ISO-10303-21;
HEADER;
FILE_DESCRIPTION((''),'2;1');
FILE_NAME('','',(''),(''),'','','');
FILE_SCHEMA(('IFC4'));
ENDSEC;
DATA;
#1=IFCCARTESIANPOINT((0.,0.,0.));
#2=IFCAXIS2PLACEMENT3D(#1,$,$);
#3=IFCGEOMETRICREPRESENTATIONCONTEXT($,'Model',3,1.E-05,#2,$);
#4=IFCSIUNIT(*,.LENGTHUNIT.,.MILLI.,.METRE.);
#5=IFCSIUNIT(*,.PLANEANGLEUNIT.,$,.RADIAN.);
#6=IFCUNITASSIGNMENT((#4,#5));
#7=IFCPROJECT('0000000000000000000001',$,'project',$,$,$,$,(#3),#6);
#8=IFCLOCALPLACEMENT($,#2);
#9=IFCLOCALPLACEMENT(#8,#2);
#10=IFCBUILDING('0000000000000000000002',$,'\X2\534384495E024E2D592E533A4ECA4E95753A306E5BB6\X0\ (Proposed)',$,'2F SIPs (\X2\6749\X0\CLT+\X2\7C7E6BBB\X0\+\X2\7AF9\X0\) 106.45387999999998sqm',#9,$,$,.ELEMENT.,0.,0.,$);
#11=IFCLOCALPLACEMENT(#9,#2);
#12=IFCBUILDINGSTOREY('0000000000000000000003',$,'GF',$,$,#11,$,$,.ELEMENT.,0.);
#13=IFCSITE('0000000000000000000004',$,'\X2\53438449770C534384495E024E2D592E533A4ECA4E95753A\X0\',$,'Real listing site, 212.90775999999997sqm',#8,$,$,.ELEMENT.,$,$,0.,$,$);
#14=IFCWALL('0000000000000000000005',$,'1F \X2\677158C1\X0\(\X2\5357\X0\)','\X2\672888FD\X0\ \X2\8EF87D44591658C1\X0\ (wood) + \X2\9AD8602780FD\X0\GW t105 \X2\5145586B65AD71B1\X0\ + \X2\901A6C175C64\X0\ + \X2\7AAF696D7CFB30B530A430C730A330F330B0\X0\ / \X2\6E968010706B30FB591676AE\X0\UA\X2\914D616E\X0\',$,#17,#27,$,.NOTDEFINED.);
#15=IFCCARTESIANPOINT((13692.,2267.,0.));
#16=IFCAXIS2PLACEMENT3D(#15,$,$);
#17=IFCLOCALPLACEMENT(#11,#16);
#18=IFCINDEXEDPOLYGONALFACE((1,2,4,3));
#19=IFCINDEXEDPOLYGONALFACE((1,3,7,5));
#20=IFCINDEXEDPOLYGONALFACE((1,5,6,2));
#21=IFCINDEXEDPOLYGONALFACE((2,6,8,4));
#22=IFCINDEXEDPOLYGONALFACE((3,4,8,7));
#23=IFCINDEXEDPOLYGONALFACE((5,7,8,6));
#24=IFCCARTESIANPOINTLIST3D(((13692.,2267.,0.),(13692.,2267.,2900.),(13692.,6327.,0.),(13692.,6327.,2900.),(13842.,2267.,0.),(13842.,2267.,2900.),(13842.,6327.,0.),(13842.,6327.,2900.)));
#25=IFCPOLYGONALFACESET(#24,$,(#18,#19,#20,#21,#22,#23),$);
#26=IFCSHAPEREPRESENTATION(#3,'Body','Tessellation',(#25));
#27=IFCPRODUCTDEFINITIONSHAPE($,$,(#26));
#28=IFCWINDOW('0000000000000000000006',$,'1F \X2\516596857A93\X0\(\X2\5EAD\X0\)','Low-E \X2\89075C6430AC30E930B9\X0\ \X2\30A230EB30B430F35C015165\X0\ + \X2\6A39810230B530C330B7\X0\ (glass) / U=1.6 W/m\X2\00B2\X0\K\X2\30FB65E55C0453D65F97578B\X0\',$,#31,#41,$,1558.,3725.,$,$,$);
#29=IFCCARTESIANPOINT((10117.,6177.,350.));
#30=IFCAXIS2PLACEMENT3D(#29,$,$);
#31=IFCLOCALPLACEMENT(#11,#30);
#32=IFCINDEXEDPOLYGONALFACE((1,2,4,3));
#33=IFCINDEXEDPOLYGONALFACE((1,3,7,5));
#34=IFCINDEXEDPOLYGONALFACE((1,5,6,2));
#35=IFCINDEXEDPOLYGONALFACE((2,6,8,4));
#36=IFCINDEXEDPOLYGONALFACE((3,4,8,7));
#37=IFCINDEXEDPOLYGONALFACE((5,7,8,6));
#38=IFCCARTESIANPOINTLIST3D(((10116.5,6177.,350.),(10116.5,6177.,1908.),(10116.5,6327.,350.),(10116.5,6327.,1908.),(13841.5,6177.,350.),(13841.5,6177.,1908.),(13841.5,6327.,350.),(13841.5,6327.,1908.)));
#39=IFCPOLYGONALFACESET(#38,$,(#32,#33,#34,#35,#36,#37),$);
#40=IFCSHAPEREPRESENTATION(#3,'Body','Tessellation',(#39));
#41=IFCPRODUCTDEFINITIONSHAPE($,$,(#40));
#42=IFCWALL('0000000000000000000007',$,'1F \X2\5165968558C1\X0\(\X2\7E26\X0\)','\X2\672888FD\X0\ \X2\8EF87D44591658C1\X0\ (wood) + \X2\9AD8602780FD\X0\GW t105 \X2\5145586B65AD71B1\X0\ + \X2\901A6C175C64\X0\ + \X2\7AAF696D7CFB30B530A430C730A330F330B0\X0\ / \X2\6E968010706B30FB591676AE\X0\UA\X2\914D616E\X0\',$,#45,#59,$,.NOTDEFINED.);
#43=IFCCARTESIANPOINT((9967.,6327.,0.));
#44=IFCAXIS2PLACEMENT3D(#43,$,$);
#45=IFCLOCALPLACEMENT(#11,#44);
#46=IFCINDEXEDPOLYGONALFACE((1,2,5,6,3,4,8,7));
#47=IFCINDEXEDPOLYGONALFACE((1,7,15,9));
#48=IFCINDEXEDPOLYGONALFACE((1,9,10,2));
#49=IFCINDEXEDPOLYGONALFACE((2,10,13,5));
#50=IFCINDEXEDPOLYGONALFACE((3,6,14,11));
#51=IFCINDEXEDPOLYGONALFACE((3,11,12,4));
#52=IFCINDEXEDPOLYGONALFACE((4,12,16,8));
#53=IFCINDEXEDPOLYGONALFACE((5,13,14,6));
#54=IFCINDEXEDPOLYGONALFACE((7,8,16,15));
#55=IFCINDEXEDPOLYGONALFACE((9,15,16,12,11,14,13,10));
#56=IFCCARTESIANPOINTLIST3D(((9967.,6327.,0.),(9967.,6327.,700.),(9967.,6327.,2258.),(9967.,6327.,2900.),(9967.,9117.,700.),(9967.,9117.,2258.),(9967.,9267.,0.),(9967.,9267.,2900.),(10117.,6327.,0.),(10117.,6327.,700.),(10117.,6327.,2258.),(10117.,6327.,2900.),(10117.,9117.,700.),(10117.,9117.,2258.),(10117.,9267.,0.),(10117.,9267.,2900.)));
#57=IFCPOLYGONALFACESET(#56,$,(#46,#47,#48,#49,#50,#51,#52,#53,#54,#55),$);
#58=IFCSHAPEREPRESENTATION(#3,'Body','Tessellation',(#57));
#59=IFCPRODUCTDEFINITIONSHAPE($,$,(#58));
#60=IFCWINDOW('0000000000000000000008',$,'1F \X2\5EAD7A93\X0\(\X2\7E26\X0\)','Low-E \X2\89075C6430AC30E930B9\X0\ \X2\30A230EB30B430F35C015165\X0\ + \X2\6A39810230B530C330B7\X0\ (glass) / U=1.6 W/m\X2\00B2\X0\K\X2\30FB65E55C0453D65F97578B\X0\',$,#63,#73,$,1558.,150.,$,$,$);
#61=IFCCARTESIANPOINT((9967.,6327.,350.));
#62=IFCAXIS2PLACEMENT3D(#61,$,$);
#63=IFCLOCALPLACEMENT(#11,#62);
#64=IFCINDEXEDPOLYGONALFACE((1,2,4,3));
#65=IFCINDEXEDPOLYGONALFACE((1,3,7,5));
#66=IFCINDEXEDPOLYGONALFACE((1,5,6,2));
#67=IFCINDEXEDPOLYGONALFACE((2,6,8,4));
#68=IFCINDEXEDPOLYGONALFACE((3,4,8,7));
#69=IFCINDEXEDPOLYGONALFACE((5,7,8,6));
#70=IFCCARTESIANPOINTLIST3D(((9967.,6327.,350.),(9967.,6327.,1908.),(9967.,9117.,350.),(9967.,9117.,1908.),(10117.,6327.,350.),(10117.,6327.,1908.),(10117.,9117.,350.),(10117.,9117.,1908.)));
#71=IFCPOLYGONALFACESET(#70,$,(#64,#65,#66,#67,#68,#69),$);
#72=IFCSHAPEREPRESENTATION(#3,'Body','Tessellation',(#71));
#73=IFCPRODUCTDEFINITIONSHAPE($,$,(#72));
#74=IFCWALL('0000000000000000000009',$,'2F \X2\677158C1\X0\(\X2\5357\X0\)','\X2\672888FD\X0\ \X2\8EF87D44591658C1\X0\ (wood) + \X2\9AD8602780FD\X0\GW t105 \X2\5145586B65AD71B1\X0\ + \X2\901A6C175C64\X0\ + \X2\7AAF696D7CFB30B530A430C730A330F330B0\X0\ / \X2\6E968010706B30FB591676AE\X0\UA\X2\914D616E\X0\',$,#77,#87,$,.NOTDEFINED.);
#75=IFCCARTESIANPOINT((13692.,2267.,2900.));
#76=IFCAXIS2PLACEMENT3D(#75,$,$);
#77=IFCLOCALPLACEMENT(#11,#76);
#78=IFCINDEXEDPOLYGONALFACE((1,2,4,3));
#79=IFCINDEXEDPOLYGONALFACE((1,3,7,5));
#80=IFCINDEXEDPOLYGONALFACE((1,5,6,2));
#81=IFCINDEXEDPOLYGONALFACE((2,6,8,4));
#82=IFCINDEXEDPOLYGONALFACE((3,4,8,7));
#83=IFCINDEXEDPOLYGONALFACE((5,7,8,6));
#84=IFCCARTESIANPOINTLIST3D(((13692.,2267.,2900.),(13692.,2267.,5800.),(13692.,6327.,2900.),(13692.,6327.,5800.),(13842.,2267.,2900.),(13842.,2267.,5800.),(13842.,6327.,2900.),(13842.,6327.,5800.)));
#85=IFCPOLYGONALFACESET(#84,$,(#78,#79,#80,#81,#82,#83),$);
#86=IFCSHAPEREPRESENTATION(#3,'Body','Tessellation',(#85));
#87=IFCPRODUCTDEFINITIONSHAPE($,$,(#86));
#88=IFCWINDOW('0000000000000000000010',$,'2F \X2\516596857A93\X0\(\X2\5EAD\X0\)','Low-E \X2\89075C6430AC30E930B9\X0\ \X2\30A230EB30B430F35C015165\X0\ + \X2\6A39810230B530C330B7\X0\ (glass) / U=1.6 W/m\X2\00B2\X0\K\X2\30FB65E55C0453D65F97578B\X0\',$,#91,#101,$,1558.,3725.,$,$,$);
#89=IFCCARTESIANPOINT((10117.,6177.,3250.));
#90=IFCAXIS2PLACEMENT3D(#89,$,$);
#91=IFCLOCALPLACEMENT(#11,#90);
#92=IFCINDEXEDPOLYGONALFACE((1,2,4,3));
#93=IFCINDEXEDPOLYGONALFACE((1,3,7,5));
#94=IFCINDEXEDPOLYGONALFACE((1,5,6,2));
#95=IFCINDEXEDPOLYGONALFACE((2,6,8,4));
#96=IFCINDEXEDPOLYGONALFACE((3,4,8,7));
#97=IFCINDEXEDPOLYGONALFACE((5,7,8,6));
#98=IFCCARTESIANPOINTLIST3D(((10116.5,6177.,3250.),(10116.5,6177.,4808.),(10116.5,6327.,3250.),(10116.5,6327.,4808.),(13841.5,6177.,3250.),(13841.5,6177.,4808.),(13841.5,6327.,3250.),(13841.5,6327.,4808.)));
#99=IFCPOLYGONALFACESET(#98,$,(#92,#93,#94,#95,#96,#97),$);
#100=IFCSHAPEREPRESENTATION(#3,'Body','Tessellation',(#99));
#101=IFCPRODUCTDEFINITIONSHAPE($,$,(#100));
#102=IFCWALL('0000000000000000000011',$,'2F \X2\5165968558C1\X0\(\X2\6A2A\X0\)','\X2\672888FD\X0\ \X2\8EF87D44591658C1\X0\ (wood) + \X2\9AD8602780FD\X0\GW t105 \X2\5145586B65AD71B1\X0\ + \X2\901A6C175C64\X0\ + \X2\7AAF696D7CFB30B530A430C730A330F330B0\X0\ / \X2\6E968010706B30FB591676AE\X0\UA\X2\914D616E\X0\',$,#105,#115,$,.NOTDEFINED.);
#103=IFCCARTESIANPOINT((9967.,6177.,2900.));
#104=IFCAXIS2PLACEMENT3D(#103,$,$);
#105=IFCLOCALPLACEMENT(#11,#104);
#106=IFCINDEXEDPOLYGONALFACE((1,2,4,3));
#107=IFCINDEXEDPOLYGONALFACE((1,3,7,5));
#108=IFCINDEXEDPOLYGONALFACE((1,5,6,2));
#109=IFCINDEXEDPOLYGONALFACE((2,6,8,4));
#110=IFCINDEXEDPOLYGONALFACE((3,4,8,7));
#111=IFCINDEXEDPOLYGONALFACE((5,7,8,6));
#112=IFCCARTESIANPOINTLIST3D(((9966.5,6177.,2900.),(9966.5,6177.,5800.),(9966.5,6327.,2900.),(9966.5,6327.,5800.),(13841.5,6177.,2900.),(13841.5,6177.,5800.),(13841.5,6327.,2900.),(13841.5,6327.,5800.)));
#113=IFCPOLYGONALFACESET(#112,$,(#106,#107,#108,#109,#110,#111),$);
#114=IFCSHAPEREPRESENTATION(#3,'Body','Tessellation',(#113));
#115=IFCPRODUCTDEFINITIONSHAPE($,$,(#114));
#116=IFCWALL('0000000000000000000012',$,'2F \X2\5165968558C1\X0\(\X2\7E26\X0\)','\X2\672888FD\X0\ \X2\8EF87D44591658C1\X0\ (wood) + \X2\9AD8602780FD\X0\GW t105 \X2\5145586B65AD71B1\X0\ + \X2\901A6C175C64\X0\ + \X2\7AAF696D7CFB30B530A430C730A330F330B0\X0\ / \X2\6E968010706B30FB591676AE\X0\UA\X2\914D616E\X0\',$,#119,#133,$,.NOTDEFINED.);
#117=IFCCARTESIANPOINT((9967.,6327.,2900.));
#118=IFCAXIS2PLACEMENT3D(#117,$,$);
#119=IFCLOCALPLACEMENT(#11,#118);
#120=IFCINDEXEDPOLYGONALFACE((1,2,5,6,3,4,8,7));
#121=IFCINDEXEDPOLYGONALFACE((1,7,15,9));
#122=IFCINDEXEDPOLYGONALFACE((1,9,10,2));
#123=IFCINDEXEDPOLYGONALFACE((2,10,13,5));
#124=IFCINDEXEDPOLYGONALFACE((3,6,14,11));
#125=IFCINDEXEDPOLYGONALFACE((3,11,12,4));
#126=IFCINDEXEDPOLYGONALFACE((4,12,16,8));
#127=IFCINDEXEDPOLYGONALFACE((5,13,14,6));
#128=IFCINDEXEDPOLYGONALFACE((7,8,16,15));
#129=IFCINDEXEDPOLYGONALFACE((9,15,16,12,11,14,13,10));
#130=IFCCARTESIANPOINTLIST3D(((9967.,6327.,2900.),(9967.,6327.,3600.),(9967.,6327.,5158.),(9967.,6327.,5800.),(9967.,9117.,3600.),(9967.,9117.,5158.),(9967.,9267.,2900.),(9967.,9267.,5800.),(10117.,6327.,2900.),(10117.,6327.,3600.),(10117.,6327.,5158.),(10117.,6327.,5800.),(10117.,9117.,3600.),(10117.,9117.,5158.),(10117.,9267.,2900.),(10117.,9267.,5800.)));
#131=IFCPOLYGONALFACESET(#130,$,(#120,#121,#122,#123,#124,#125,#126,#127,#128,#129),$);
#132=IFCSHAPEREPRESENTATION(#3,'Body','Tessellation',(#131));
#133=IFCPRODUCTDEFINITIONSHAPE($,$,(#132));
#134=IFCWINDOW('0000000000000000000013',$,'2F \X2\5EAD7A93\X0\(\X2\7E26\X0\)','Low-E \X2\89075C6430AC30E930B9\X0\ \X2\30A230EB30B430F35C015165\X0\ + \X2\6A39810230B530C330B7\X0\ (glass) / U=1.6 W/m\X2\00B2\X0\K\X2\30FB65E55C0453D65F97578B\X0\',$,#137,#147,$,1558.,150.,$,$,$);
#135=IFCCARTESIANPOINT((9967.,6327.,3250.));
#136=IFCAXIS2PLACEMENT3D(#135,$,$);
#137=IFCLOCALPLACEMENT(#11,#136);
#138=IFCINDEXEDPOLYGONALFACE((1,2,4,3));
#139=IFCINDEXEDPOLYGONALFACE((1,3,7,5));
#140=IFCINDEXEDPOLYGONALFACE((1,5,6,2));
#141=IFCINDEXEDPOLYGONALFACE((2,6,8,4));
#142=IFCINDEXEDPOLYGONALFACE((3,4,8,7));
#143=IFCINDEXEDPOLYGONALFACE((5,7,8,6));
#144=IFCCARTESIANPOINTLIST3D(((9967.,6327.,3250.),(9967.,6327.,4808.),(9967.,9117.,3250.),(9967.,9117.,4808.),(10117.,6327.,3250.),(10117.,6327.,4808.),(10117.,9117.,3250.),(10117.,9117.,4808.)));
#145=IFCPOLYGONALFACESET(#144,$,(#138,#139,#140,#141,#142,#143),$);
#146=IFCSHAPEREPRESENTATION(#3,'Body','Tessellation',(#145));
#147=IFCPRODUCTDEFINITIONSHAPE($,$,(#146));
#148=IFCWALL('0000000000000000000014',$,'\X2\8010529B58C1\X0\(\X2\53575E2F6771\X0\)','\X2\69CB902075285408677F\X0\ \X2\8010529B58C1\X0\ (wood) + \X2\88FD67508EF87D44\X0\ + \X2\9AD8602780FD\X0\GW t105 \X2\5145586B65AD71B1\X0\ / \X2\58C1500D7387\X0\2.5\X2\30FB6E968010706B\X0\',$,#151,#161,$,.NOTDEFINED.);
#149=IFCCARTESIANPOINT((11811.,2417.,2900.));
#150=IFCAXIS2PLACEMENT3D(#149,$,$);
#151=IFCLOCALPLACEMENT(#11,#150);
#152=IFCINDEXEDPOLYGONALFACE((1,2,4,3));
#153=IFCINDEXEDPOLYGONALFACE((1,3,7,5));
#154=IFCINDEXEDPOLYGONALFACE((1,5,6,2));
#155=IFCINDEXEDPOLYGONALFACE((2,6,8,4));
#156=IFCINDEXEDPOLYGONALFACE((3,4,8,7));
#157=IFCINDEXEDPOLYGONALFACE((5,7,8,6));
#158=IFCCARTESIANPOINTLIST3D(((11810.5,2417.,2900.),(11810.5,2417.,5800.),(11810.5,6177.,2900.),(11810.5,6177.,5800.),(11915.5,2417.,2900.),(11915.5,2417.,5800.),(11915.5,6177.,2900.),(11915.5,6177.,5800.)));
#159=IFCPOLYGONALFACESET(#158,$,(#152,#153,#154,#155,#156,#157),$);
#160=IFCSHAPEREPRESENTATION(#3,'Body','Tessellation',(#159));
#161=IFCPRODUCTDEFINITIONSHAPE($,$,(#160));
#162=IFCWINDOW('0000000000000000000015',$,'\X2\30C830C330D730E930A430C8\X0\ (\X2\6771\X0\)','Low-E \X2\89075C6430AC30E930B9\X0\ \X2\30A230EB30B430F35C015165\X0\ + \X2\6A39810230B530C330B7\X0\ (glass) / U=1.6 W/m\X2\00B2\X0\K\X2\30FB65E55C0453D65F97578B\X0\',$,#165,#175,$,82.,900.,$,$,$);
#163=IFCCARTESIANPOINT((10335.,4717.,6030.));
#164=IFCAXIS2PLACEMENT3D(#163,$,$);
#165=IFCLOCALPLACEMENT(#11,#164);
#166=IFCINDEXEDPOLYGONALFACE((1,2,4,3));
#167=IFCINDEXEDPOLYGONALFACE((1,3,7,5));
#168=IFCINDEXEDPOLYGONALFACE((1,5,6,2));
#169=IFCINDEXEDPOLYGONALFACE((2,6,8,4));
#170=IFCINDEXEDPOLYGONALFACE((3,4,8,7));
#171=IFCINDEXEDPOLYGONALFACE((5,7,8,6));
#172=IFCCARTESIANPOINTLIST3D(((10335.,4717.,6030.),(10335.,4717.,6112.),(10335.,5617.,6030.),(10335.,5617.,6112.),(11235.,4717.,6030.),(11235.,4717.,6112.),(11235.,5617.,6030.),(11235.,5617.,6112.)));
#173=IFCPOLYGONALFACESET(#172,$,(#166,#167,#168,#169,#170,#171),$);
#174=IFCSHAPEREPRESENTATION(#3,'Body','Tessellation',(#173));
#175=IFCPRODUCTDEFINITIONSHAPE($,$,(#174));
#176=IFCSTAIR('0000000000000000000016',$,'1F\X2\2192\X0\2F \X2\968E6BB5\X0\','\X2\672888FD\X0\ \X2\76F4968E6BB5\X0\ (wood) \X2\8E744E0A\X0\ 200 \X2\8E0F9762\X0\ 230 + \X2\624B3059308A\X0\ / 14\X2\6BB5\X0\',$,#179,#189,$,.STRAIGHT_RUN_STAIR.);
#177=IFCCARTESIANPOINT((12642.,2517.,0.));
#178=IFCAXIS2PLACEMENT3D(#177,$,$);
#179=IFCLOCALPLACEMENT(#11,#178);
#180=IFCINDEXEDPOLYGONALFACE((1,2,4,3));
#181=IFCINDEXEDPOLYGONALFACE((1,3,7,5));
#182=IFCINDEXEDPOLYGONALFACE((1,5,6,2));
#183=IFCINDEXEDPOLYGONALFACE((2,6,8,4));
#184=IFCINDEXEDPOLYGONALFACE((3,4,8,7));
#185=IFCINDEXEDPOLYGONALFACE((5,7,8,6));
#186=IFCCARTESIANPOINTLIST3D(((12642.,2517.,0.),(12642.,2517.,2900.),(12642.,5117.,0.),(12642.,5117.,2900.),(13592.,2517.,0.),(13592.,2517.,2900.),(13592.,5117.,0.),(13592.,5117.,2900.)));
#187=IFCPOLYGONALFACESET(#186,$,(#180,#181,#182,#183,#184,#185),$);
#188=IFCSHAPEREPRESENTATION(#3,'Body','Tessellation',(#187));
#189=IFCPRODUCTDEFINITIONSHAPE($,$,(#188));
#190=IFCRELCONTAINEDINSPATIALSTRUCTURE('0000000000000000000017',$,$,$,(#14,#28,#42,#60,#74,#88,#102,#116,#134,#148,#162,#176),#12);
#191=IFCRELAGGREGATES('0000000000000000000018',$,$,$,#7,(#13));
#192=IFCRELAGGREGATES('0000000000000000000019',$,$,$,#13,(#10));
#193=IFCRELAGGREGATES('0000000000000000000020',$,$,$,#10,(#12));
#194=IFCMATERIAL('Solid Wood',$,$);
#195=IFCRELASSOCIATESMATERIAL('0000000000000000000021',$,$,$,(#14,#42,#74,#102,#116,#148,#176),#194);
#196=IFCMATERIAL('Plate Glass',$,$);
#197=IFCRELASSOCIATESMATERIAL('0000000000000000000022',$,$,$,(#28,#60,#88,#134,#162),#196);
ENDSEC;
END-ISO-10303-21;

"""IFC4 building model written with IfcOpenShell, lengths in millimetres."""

from ifc_helpers import new_model, si_unit, frame, frame_2d, origin, place, context, project, spatial, rectangle, extrude, material, element, fill, save


model = new_model("IFC4")

# Units and contexts
model_context = context("Model", 3, precision=1e-05, world=origin())
ifc_project = project(units=[si_unit("LENGTHUNIT", "METRE", prefix="MILLI"), si_unit("PLANEANGLEUNIT", "RADIAN")], contexts=[model_context])

# Site, building, storey
site_placement = place(None, origin())
site = spatial("IfcSite", under=ifc_project, at=site_placement, Name="千葉県千葉市中央区今井町", ObjectType="Real listing site, 212.90775999999997sqm", CompositionType="ELEMENT", RefElevation=0.0)
building_placement = place(site_placement, origin())
building = spatial("IfcBuilding", under=site, at=building_placement, Name="千葉市中央区今井町の家 (Proposed)", ObjectType="2F SIPs (杉CLT+籾殻+竹) 106.45387999999998sqm", CompositionType="ELEMENT", ElevationOfRefHeight=0.0, ElevationOfTerrain=0.0)
storey_placement = place(building_placement, origin())
storey = spatial("IfcBuildingStorey", under=building, at=storey_placement, Name="GF", CompositionType="ELEMENT", Elevation=0.0)

# Shared definitions
ifc_material_1 = material(Name="Solid Wood")

# Wall, opening, window
wall_1_placement = place(storey_placement, frame((13692.0, 2267.0, 0.0)))
wall_1 = element("IfcWall", 1, at=wall_1_placement, inside=storey, material=ifc_material_1, Name="1F 東壁(南)", Description="木製 軸組外壁 (wood) + 高性能GW t105 充填断熱 + 通気層 + 窯業系サイディング / 準耐火・外皮UA配慮", PredefinedType="NOTDEFINED", context=model_context, shape_type="SweptSolid", body=[
    extrude(rectangle(XDim=150.0, YDim=4060.0, at=frame_2d((75.0, 2030.0))), frame((13692.0, 2267.0, 0.0)), (0.0, 0.0, 1.0), 2900.0),
])
opening_1_placement = place(storey_placement, frame((10117.0, 6177.0, 350.0)))
opening_1 = element("IfcOpeningElement", 2, at=opening_1_placement, cuts=wall_1, PredefinedType="NOTDEFINED", context=model_context, shape_type="SweptSolid", body=[
    extrude(rectangle(XDim=3725.0, YDim=150.0, at=frame_2d((1862.0, 75.0))), frame((10117.0, 6177.0, 350.0)), (0.0, 0.0, 1.0), 1558.0),
])
ifc_material_2 = material(Name="Plate Glass")
window_1_placement = place(storey_placement, frame((10117.0, 6177.0, 350.0)))
window_1 = element("IfcWindow", 3, at=window_1_placement, inside=storey, material=ifc_material_2, Name="1F 入隅窓(庭)", Description="Low-E 複層ガラス アルゴン封入 + 樹脂サッシ (glass) / U=1.6 W/m²K・日射取得型", OverallHeight=1558.0, OverallWidth=3725.0, context=model_context, shape_type="SweptSolid", body=[
    extrude(rectangle(XDim=3725.0, YDim=150.0, at=frame_2d((1862.0, 75.0))), frame((10117.0, 6177.0, 350.0)), (0.0, 0.0, 1.0), 1558.0),
])
fill(opening_1, window_1)

# Wall, opening, window
wall_2_placement = place(storey_placement, frame((9967.0, 6327.0, 0.0)))
wall_2 = element("IfcWall", 4, at=wall_2_placement, inside=storey, material=ifc_material_1, Name="1F 入隅壁(縦)", Description="木製 軸組外壁 (wood) + 高性能GW t105 充填断熱 + 通気層 + 窯業系サイディング / 準耐火・外皮UA配慮", PredefinedType="NOTDEFINED", context=model_context, shape_type="SweptSolid", body=[
    extrude(rectangle(XDim=150.0, YDim=2940.0, at=frame_2d((75.0, 1470.0))), frame((9967.0, 6327.0, 0.0)), (0.0, 0.0, 1.0), 2900.0),
])
opening_2_placement = place(storey_placement, frame((9967.0, 6327.0, 350.0)))
opening_2 = element("IfcOpeningElement", 5, at=opening_2_placement, cuts=wall_2, PredefinedType="NOTDEFINED", context=model_context, shape_type="SweptSolid", body=[
    extrude(rectangle(XDim=150.0, YDim=2790.0, at=frame_2d((75.0, 1395.0))), frame((9967.0, 6327.0, 350.0)), (0.0, 0.0, 1.0), 1558.0),
])
window_2_placement = place(storey_placement, frame((9967.0, 6327.0, 350.0)))
window_2 = element("IfcWindow", 6, at=window_2_placement, inside=storey, material=ifc_material_2, Name="1F 庭窓(縦)", Description="Low-E 複層ガラス アルゴン封入 + 樹脂サッシ (glass) / U=1.6 W/m²K・日射取得型", OverallHeight=1558.0, OverallWidth=150.0, context=model_context, shape_type="SweptSolid", body=[
    extrude(rectangle(XDim=150.0, YDim=2790.0, at=frame_2d((75.0, 1395.0))), frame((9967.0, 6327.0, 350.0)), (0.0, 0.0, 1.0), 1558.0),
])
fill(opening_2, window_2)

# Wall, opening, window
wall_3_placement = place(storey_placement, frame((13692.0, 2267.0, 2900.0)))
wall_3 = element("IfcWall", 7, at=wall_3_placement, inside=storey, material=ifc_material_1, Name="2F 東壁(南)", Description="木製 軸組外壁 (wood) + 高性能GW t105 充填断熱 + 通気層 + 窯業系サイディング / 準耐火・外皮UA配慮", PredefinedType="NOTDEFINED", context=model_context, shape_type="SweptSolid", body=[
    extrude(rectangle(XDim=150.0, YDim=4060.0, at=frame_2d((75.0, 2030.0))), frame((13692.0, 2267.0, 2900.0)), (0.0, 0.0, 1.0), 2900.0),
])
opening_3_placement = place(storey_placement, frame((10117.0, 6177.0, 3250.0)))
opening_3 = element("IfcOpeningElement", 8, at=opening_3_placement, cuts=wall_3, PredefinedType="NOTDEFINED", context=model_context, shape_type="SweptSolid", body=[
    extrude(rectangle(XDim=3725.0, YDim=150.0, at=frame_2d((1862.0, 75.0))), frame((10117.0, 6177.0, 3250.0)), (0.0, 0.0, 1.0), 1558.0),
])
window_3_placement = place(storey_placement, frame((10117.0, 6177.0, 3250.0)))
window_3 = element("IfcWindow", 9, at=window_3_placement, inside=storey, material=ifc_material_2, Name="2F 入隅窓(庭)", Description="Low-E 複層ガラス アルゴン封入 + 樹脂サッシ (glass) / U=1.6 W/m²K・日射取得型", OverallHeight=1558.0, OverallWidth=3725.0, context=model_context, shape_type="SweptSolid", body=[
    extrude(rectangle(XDim=3725.0, YDim=150.0, at=frame_2d((1862.0, 75.0))), frame((10117.0, 6177.0, 3250.0)), (0.0, 0.0, 1.0), 1558.0),
])
fill(opening_3, window_3)

# Wall
wall_4_placement = place(storey_placement, frame((9967.0, 6177.0, 2900.0)))
element("IfcWall", 10, at=wall_4_placement, inside=storey, material=ifc_material_1, Name="2F 入隅壁(横)", Description="木製 軸組外壁 (wood) + 高性能GW t105 充填断熱 + 通気層 + 窯業系サイディング / 準耐火・外皮UA配慮", PredefinedType="NOTDEFINED", context=model_context, shape_type="SweptSolid", body=[
    extrude(rectangle(XDim=3875.0, YDim=150.0, at=frame_2d((1937.0, 75.0))), frame((9967.0, 6177.0, 2900.0)), (0.0, 0.0, 1.0), 2900.0),
])

# Wall, opening, window
wall_5_placement = place(storey_placement, frame((9967.0, 6327.0, 2900.0)))
wall_5 = element("IfcWall", 11, at=wall_5_placement, inside=storey, material=ifc_material_1, Name="2F 入隅壁(縦)", Description="木製 軸組外壁 (wood) + 高性能GW t105 充填断熱 + 通気層 + 窯業系サイディング / 準耐火・外皮UA配慮", PredefinedType="NOTDEFINED", context=model_context, shape_type="SweptSolid", body=[
    extrude(rectangle(XDim=150.0, YDim=2940.0, at=frame_2d((75.0, 1470.0))), frame((9967.0, 6327.0, 2900.0)), (0.0, 0.0, 1.0), 2900.0),
])
opening_4_placement = place(storey_placement, frame((9967.0, 6327.0, 3250.0)))
opening_4 = element("IfcOpeningElement", 12, at=opening_4_placement, cuts=wall_5, PredefinedType="NOTDEFINED", context=model_context, shape_type="SweptSolid", body=[
    extrude(rectangle(XDim=150.0, YDim=2790.0, at=frame_2d((75.0, 1395.0))), frame((9967.0, 6327.0, 3250.0)), (0.0, 0.0, 1.0), 1558.0),
])
window_4_placement = place(storey_placement, frame((9967.0, 6327.0, 3250.0)))
window_4 = element("IfcWindow", 13, at=window_4_placement, inside=storey, material=ifc_material_2, Name="2F 庭窓(縦)", Description="Low-E 複層ガラス アルゴン封入 + 樹脂サッシ (glass) / U=1.6 W/m²K・日射取得型", OverallHeight=1558.0, OverallWidth=150.0, context=model_context, shape_type="SweptSolid", body=[
    extrude(rectangle(XDim=150.0, YDim=2790.0, at=frame_2d((75.0, 1395.0))), frame((9967.0, 6327.0, 3250.0)), (0.0, 0.0, 1.0), 1558.0),
])
fill(opening_4, window_4)

# Wall
wall_6_placement = place(storey_placement, frame((11811.0, 2417.0, 2900.0)))
element("IfcWall", 14, at=wall_6_placement, inside=storey, material=ifc_material_1, Name="耐力壁(南帯東)", Description="構造用合板 耐力壁 (wood) + 製材軸組 + 高性能GW t105 充填断熱 / 壁倍率2.5・準耐火", PredefinedType="NOTDEFINED", context=model_context, shape_type="SweptSolid", body=[
    extrude(rectangle(XDim=105.0, YDim=3760.0, at=frame_2d((52.0, 1880.0))), frame((11811.0, 2417.0, 2900.0)), (0.0, 0.0, 1.0), 2900.0),
])

# Window
window_5_placement = place(storey_placement, frame((10335.0, 4717.0, 6030.0)))
element("IfcWindow", 15, at=window_5_placement, inside=storey, material=ifc_material_2, Name="トップライト (東)", Description="Low-E 複層ガラス アルゴン封入 + 樹脂サッシ (glass) / U=1.6 W/m²K・日射取得型", OverallHeight=82.0, OverallWidth=900.0, context=model_context, shape_type="SweptSolid", body=[
    extrude(rectangle(XDim=900.0, YDim=900.0, at=frame_2d((450.0, 450.0))), frame((10335.0, 4717.0, 6030.0)), (0.0, 0.0, 1.0), 82.0),
])

# Stair
stair_placement = place(storey_placement, frame((12642.0, 2517.0, 0.0)))
element("IfcStair", 16, at=stair_placement, inside=storey, material=ifc_material_1, Name="1F→2F 階段", Description="木製 直階段 (wood) 蹴上 200 踏面 230 + 手すり / 14段", PredefinedType="STRAIGHT_RUN_STAIR", context=model_context, shape_type="SweptSolid", body=[
    extrude(rectangle(XDim=950.0, YDim=2600.0, at=frame_2d((475.0, 1300.0))), frame((12642.0, 2517.0, 0.0)), (0.0, 0.0, 1.0), 2900.0),
])

save(model, "model.ifc")
